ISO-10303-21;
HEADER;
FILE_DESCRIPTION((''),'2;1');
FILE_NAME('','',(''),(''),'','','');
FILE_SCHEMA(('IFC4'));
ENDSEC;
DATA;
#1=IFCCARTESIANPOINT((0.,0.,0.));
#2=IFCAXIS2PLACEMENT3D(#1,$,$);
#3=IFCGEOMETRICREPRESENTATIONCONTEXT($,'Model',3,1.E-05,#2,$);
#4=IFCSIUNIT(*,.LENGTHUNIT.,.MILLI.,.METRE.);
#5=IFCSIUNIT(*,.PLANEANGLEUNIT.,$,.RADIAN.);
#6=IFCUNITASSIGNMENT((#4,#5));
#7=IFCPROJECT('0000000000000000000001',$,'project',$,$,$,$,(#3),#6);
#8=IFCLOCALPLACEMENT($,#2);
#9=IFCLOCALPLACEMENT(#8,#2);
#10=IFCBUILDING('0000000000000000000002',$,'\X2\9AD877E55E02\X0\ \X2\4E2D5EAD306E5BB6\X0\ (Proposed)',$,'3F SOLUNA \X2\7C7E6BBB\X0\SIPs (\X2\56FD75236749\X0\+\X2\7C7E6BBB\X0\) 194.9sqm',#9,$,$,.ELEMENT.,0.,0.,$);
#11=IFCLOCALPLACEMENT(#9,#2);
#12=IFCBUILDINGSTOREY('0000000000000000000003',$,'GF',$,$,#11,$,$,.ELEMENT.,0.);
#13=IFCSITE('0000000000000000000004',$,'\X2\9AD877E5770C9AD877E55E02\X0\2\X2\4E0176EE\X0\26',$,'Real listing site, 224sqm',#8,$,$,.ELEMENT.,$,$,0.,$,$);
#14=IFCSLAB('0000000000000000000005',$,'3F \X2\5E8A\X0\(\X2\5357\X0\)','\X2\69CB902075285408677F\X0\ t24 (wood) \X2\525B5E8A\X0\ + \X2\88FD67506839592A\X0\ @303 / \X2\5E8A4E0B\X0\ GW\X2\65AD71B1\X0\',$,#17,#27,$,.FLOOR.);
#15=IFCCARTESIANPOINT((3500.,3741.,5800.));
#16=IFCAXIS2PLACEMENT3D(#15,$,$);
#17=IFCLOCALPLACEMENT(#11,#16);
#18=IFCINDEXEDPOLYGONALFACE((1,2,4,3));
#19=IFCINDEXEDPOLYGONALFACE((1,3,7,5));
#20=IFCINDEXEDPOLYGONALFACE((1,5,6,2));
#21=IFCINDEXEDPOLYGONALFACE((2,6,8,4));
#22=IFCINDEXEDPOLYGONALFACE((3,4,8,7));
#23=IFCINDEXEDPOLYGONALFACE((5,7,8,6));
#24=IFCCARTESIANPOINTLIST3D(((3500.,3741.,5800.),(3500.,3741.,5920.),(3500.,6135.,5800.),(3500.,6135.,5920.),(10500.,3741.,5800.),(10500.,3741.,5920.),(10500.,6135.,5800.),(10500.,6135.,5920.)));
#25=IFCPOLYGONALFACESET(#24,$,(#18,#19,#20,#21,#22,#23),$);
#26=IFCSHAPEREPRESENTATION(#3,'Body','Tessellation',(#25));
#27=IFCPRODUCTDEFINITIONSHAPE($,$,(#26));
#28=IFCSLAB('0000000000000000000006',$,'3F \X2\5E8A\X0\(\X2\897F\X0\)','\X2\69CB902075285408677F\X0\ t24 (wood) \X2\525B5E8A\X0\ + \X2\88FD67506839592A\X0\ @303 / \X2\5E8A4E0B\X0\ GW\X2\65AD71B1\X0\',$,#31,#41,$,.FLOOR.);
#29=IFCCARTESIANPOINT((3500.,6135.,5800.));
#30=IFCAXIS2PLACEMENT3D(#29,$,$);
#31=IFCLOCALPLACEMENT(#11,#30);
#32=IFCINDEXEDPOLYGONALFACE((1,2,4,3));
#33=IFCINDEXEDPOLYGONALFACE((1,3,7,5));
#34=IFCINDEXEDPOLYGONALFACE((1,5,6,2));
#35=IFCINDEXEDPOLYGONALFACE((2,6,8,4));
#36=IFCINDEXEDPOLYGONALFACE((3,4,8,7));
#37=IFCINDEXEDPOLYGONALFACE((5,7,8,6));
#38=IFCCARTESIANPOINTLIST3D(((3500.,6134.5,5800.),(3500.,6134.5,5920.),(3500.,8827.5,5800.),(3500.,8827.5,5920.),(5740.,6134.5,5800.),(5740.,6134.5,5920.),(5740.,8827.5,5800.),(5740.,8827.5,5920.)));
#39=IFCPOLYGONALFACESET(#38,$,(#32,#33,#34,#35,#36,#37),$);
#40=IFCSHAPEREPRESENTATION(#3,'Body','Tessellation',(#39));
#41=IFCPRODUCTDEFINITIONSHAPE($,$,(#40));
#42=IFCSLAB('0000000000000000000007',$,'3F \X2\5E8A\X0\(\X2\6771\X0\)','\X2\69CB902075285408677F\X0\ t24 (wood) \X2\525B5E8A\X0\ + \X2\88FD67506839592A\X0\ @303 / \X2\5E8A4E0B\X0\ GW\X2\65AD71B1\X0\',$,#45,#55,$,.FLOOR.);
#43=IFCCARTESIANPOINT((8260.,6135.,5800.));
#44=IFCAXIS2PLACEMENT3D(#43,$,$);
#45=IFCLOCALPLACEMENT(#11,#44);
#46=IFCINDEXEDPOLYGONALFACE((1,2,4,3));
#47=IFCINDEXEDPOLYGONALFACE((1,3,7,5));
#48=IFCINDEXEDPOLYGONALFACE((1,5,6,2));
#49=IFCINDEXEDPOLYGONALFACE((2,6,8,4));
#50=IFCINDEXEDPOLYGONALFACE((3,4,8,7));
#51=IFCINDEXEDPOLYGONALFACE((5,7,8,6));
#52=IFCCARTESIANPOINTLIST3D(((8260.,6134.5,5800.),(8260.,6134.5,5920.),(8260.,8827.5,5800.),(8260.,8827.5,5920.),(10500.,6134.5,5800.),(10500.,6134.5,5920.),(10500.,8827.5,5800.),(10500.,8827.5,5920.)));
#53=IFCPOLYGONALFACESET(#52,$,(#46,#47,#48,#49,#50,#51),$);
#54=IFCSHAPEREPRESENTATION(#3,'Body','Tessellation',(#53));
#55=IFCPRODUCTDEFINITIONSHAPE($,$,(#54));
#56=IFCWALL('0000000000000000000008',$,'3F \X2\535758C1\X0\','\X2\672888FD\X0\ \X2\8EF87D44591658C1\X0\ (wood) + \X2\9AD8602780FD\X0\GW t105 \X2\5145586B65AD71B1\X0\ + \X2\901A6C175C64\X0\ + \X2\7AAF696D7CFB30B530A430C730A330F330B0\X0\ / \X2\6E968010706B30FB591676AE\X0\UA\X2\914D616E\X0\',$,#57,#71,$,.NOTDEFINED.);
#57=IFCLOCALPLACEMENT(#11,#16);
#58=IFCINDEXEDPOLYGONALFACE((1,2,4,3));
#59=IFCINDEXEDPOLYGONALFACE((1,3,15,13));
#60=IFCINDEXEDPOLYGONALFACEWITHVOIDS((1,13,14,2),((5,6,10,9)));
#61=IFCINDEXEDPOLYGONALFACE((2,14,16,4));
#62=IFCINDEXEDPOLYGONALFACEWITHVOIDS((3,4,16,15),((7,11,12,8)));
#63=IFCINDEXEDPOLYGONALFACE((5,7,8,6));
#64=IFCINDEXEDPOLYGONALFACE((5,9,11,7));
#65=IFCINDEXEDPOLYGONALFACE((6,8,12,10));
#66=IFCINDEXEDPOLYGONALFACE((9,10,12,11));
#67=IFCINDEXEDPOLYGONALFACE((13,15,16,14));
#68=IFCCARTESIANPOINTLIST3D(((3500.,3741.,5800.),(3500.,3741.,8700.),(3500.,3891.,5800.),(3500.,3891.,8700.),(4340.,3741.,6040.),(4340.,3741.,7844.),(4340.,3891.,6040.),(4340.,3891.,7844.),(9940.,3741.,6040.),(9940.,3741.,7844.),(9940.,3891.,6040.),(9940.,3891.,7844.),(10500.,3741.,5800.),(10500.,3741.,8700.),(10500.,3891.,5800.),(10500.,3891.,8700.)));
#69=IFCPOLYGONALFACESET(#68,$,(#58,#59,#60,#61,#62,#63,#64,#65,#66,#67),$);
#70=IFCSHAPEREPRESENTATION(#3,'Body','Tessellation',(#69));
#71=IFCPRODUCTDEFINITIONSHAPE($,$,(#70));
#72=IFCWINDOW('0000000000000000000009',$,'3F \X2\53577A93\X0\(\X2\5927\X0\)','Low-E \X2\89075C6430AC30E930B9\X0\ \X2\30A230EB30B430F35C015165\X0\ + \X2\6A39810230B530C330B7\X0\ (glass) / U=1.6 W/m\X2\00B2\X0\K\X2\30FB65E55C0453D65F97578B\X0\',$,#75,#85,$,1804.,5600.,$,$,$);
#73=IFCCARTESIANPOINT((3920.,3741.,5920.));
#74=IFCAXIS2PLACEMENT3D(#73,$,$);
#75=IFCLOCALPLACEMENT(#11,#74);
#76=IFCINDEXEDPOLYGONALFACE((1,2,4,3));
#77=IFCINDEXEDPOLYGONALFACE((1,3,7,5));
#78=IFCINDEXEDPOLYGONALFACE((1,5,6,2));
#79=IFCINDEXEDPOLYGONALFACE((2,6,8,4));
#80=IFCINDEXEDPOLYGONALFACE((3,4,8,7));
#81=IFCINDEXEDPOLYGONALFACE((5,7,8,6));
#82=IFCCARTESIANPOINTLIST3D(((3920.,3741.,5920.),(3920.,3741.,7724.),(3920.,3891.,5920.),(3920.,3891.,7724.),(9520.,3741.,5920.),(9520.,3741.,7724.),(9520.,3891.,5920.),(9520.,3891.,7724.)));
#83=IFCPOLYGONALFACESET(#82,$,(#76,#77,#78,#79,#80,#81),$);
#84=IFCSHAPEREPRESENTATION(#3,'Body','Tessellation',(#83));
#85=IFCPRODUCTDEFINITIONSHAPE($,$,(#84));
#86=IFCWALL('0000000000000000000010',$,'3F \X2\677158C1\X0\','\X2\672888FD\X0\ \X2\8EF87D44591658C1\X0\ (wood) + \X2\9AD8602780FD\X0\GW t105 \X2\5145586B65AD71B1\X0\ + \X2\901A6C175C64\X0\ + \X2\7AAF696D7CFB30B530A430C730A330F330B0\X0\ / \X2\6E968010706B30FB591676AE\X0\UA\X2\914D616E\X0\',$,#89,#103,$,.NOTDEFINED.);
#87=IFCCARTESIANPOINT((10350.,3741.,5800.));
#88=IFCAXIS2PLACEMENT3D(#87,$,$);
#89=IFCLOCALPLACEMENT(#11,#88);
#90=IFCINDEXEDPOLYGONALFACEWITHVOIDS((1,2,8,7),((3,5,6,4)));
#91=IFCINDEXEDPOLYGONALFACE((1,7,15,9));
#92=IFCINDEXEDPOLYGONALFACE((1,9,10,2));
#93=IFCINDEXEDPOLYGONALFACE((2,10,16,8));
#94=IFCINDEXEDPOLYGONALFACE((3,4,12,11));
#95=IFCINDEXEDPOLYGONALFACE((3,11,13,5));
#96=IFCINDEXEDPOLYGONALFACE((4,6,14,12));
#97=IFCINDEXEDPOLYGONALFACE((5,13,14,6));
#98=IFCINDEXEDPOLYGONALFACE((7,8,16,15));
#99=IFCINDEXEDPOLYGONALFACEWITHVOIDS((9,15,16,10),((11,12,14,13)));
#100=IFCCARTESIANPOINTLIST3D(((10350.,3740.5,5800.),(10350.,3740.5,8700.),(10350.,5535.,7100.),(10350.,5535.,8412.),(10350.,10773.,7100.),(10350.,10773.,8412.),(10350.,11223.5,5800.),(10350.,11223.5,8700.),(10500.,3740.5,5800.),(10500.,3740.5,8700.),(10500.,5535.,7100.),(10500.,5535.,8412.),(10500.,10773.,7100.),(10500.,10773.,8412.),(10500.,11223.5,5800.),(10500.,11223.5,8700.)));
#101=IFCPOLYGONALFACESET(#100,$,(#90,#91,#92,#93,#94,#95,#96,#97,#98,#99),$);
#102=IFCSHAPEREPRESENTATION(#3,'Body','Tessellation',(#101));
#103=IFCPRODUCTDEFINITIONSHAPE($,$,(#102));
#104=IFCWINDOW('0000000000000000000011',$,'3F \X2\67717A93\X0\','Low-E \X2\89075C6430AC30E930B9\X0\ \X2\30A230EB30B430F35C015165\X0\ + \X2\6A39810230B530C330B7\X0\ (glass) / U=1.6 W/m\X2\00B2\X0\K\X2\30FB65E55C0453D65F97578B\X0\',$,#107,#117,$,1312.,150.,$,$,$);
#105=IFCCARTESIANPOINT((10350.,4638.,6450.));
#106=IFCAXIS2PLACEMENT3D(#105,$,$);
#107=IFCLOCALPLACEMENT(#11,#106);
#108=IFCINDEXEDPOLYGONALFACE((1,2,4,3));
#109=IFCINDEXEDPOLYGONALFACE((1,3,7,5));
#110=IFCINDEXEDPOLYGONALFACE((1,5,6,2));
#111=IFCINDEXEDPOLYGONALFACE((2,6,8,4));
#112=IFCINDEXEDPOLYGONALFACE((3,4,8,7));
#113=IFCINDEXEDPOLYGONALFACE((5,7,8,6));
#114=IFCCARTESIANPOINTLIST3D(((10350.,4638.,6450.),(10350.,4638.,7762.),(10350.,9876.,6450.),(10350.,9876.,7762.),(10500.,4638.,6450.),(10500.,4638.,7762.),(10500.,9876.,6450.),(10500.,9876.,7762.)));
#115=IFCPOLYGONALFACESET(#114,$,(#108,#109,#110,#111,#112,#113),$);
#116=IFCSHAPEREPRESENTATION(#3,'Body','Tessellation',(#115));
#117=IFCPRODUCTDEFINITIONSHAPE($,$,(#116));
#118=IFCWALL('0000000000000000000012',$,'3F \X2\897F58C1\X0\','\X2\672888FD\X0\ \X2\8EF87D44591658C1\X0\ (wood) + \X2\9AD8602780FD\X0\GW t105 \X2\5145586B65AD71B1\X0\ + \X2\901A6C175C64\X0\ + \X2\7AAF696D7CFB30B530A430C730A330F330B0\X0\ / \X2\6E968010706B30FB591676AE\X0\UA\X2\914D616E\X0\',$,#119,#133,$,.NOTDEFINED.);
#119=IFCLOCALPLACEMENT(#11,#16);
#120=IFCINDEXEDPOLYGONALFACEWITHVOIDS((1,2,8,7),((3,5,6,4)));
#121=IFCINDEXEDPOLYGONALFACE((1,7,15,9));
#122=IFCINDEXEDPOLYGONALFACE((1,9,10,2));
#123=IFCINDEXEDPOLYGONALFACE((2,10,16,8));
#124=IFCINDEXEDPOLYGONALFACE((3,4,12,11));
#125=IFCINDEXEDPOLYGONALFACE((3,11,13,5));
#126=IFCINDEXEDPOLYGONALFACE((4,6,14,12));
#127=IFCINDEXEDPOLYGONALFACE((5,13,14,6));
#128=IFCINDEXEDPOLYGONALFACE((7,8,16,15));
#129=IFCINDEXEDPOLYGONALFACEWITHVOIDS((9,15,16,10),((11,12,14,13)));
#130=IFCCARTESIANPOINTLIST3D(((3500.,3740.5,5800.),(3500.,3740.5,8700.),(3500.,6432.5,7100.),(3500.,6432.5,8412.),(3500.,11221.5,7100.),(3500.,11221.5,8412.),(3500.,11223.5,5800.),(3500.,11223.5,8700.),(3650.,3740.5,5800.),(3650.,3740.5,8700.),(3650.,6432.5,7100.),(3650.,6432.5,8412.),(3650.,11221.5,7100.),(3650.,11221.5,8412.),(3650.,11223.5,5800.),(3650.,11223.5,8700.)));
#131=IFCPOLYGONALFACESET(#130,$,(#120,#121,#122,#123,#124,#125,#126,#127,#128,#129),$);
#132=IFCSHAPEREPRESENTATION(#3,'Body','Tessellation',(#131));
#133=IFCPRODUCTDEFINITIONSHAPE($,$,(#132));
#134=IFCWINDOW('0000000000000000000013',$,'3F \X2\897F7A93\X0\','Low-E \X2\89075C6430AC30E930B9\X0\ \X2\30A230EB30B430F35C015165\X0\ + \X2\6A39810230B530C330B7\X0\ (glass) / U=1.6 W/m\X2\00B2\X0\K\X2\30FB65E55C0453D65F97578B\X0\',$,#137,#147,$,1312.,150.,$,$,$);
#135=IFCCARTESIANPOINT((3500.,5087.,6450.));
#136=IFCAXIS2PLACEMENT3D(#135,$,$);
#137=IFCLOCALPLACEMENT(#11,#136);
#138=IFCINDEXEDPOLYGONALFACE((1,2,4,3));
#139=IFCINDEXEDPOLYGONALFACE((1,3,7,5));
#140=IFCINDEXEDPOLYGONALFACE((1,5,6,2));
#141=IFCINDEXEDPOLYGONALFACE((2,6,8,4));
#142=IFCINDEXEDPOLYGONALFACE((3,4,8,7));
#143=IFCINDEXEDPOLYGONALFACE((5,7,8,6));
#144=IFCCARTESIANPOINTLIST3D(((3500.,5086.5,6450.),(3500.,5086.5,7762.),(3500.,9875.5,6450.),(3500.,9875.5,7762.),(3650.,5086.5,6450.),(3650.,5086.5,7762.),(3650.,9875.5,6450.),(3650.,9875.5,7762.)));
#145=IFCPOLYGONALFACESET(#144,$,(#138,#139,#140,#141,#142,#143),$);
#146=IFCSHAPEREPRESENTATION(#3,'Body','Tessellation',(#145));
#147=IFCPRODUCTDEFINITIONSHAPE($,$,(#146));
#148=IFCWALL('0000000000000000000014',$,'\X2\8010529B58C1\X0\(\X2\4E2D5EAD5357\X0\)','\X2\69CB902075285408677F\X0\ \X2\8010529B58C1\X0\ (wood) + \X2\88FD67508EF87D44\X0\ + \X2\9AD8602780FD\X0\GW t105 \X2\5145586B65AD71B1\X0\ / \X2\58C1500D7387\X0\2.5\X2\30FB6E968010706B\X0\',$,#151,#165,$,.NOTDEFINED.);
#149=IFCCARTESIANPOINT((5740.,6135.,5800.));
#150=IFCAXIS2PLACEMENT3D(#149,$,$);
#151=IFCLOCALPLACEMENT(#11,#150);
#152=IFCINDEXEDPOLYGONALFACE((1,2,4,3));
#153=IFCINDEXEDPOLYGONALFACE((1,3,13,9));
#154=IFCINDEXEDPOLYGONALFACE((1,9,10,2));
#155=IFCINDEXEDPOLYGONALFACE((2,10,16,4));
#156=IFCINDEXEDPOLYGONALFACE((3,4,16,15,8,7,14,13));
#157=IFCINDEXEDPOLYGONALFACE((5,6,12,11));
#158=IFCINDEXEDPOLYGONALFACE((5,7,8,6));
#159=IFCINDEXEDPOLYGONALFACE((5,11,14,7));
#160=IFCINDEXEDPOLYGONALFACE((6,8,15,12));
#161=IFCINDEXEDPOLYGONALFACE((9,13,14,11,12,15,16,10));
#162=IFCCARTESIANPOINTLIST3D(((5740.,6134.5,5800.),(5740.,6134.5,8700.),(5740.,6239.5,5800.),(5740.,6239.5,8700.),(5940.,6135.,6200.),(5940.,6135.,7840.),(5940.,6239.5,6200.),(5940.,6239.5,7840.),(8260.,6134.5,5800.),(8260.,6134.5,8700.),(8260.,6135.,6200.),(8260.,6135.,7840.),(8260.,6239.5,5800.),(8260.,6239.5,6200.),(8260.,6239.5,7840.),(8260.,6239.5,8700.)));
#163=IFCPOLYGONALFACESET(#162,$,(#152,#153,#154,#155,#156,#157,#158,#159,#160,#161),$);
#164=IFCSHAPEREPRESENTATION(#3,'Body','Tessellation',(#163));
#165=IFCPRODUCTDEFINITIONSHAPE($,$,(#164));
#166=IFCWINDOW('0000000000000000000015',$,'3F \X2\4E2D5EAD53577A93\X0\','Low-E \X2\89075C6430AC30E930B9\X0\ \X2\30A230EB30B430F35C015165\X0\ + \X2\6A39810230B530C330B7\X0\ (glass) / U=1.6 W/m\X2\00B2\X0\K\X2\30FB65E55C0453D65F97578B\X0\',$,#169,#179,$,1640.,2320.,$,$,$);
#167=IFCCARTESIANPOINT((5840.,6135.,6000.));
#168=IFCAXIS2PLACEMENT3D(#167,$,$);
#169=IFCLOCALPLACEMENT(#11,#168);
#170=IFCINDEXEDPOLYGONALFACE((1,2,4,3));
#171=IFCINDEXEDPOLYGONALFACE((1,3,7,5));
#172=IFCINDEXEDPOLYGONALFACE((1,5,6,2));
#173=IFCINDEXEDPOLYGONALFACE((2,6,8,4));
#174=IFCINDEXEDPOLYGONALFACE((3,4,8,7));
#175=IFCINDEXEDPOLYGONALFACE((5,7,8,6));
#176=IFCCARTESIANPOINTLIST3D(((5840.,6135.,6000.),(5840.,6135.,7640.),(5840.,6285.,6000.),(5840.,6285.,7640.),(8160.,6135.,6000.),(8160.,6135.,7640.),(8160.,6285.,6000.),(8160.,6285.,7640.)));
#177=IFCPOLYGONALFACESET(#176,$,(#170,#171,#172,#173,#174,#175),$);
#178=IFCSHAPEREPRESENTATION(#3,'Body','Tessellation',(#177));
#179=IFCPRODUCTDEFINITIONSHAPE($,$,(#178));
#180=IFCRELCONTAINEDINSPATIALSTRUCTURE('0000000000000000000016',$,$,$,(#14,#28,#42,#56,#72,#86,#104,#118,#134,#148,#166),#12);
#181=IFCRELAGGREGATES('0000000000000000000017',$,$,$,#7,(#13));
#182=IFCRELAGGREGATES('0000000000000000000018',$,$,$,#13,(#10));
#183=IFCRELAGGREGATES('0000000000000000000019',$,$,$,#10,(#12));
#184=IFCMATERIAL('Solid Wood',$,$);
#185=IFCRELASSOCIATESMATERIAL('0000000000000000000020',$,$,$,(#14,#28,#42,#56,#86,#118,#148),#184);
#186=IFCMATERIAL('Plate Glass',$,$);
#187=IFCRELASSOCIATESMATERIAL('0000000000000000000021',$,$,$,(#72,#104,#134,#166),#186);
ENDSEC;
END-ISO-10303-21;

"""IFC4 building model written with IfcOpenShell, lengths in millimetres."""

from ifc_helpers import new_model, si_unit, frame, frame_2d, origin, place, context, project, spatial, rectangle, extrude, material, element, fill, save


model = new_model("IFC4")

# Units and contexts
model_context = context("Model", 3, precision=1e-05, world=origin())
ifc_project = project(units=[si_unit("LENGTHUNIT", "METRE", prefix="MILLI"), si_unit("PLANEANGLEUNIT", "RADIAN")], contexts=[model_context])

# Site, building, storey
site_placement = place(None, origin())
site = spatial("IfcSite", under=ifc_project, at=site_placement, Name="高知県高知市2丁目26", ObjectType="Real listing site, 224sqm", CompositionType="ELEMENT", RefElevation=0.0)
building_placement = place(site_placement, origin())
building = spatial("IfcBuilding", under=site, at=building_placement, Name="高知市 中庭の家 (Proposed)", ObjectType="3F SOLUNA 籾殻SIPs (国産杉+籾殻) 194.9sqm", CompositionType="ELEMENT", ElevationOfRefHeight=0.0, ElevationOfTerrain=0.0)
storey_placement = place(building_placement, origin())
storey = spatial("IfcBuildingStorey", under=building, at=storey_placement, Name="GF", CompositionType="ELEMENT", Elevation=0.0)

# Slabs
ifc_material_1 = material(Name="Solid Wood")
slab_1_placement = place(storey_placement, frame((3500.0, 3741.0, 5800.0)))
element("IfcSlab", 1, at=slab_1_placement, inside=storey, material=ifc_material_1, Name="3F 床(南)", Description="構造用合板 t24 (wood) 剛床 + 製材根太 @303 / 床下 GW断熱", PredefinedType="FLOOR", context=model_context, shape_type="SweptSolid", body=[
    extrude(rectangle(XDim=7000.0, YDim=2394.0, at=frame_2d((3500.0, 1197.0))), frame((3500.0, 3741.0, 5800.0)), (0.0, 0.0, 1.0), 120.0),
])
slab_2_placement = place(storey_placement, frame((3500.0, 6135.0, 5800.0)))
element("IfcSlab", 2, at=slab_2_placement, inside=storey, material=ifc_material_1, Name="3F 床(西)", Description="構造用合板 t24 (wood) 剛床 + 製材根太 @303 / 床下 GW断熱", PredefinedType="FLOOR", context=model_context, shape_type="SweptSolid", body=[
    extrude(rectangle(XDim=2240.0, YDim=2693.0, at=frame_2d((1120.0, 1346.0))), frame((3500.0, 6135.0, 5800.0)), (0.0, 0.0, 1.0), 120.0),
])
slab_3_placement = place(storey_placement, frame((8260.0, 6135.0, 5800.0)))
element("IfcSlab", 3, at=slab_3_placement, inside=storey, material=ifc_material_1, Name="3F 床(東)", Description="構造用合板 t24 (wood) 剛床 + 製材根太 @303 / 床下 GW断熱", PredefinedType="FLOOR", context=model_context, shape_type="SweptSolid", body=[
    extrude(rectangle(XDim=2240.0, YDim=2693.0, at=frame_2d((1120.0, 1346.0))), frame((8260.0, 6135.0, 5800.0)), (0.0, 0.0, 1.0), 120.0),
])

# Walls, openings, windows
wall_1_placement = place(storey_placement, frame((3500.0, 3741.0, 5800.0)))
wall_1 = element("IfcWall", 4, at=wall_1_placement, inside=storey, material=ifc_material_1, Name="3F 南壁", Description="木製 軸組外壁 (wood) + 高性能GW t105 充填断熱 + 通気層 + 窯業系サイディング / 準耐火・外皮UA配慮", PredefinedType="NOTDEFINED", context=model_context, shape_type="SweptSolid", body=[
    extrude(rectangle(XDim=7000.0, YDim=150.0, at=frame_2d((3500.0, 75.0))), frame((3500.0, 3741.0, 5800.0)), (0.0, 0.0, 1.0), 2900.0),
])
opening_1_placement = place(storey_placement, frame((3920.0, 3741.0, 5920.0)))
opening_1 = element("IfcOpeningElement", 5, at=opening_1_placement, cuts=wall_1, PredefinedType="NOTDEFINED", context=model_context, shape_type="SweptSolid", body=[
    extrude(rectangle(XDim=5600.0, YDim=150.0, at=frame_2d((2800.0, 75.0))), frame((3920.0, 3741.0, 5920.0)), (0.0, 0.0, 1.0), 1804.0),
])
ifc_material_2 = material(Name="Plate Glass")
window_1_placement = place(storey_placement, frame((3920.0, 3741.0, 5920.0)))
window_1 = element("IfcWindow", 6, at=window_1_placement, inside=storey, material=ifc_material_2, Name="3F 南窓(大)", Description="Low-E 複層ガラス アルゴン封入 + 樹脂サッシ (glass) / U=1.6 W/m²K・日射取得型", OverallHeight=1804.0, OverallWidth=5600.0, context=model_context, shape_type="SweptSolid", body=[
    extrude(rectangle(XDim=5600.0, YDim=150.0, at=frame_2d((2800.0, 75.0))), frame((3920.0, 3741.0, 5920.0)), (0.0, 0.0, 1.0), 1804.0),
])
fill(opening_1, window_1)
wall_2_placement = place(storey_placement, frame((10350.0, 3741.0, 5800.0)))
wall_2 = element("IfcWall", 7, at=wall_2_placement, inside=storey, material=ifc_material_1, Name="3F 東壁", Description="木製 軸組外壁 (wood) + 高性能GW t105 充填断熱 + 通気層 + 窯業系サイディング / 準耐火・外皮UA配慮", PredefinedType="NOTDEFINED", context=model_context, shape_type="SweptSolid", body=[
    extrude(rectangle(XDim=150.0, YDim=7483.0, at=frame_2d((75.0, 3741.0))), frame((10350.0, 3741.0, 5800.0)), (0.0, 0.0, 1.0), 2900.0),
])
opening_2_placement = place(storey_placement, frame((10350.0, 4638.0, 6450.0)))
opening_2 = element("IfcOpeningElement", 8, at=opening_2_placement, cuts=wall_2, PredefinedType="NOTDEFINED", context=model_context, shape_type="SweptSolid", body=[
    extrude(rectangle(XDim=150.0, YDim=5238.0, at=frame_2d((75.0, 2619.0))), frame((10350.0, 4638.0, 6450.0)), (0.0, 0.0, 1.0), 1312.0),
])
window_2_placement = place(storey_placement, frame((10350.0, 4638.0, 6450.0)))
window_2 = element("IfcWindow", 9, at=window_2_placement, inside=storey, material=ifc_material_2, Name="3F 東窓", Description="Low-E 複層ガラス アルゴン封入 + 樹脂サッシ (glass) / U=1.6 W/m²K・日射取得型", OverallHeight=1312.0, OverallWidth=150.0, context=model_context, shape_type="SweptSolid", body=[
    extrude(rectangle(XDim=150.0, YDim=5238.0, at=frame_2d((75.0, 2619.0))), frame((10350.0, 4638.0, 6450.0)), (0.0, 0.0, 1.0), 1312.0),
])
fill(opening_2, window_2)
wall_3_placement = place(storey_placement, frame((3500.0, 3741.0, 5800.0)))
wall_3 = element("IfcWall", 10, at=wall_3_placement, inside=storey, material=ifc_material_1, Name="3F 西壁", Description="木製 軸組外壁 (wood) + 高性能GW t105 充填断熱 + 通気層 + 窯業系サイディング / 準耐火・外皮UA配慮", PredefinedType="NOTDEFINED", context=model_context, shape_type="SweptSolid", body=[
    extrude(rectangle(XDim=150.0, YDim=7483.0, at=frame_2d((75.0, 3741.0))), frame((3500.0, 3741.0, 5800.0)), (0.0, 0.0, 1.0), 2900.0),
])
opening_3_placement = place(storey_placement, frame((3500.0, 5087.0, 6450.0)))
opening_3 = element("IfcOpeningElement", 11, at=opening_3_placement, cuts=wall_3, PredefinedType="NOTDEFINED", context=model_context, shape_type="SweptSolid", body=[
    extrude(rectangle(XDim=150.0, YDim=4789.0, at=frame_2d((75.0, 2394.0))), frame((3500.0, 5087.0, 6450.0)), (0.0, 0.0, 1.0), 1312.0),
])
window_3_placement = place(storey_placement, frame((3500.0, 5087.0, 6450.0)))
window_3 = element("IfcWindow", 12, at=window_3_placement, inside=storey, material=ifc_material_2, Name="3F 西窓", Description="Low-E 複層ガラス アルゴン封入 + 樹脂サッシ (glass) / U=1.6 W/m²K・日射取得型", OverallHeight=1312.0, OverallWidth=150.0, context=model_context, shape_type="SweptSolid", body=[
    extrude(rectangle(XDim=150.0, YDim=4789.0, at=frame_2d((75.0, 2394.0))), frame((3500.0, 5087.0, 6450.0)), (0.0, 0.0, 1.0), 1312.0),
])
fill(opening_3, window_3)
wall_4_placement = place(storey_placement, frame((5740.0, 6135.0, 5800.0)))
wall_4 = element("IfcWall", 13, at=wall_4_placement, inside=storey, material=ifc_material_1, Name="耐力壁(中庭南)", Description="構造用合板 耐力壁 (wood) + 製材軸組 + 高性能GW t105 充填断熱 / 壁倍率2.5・準耐火", PredefinedType="NOTDEFINED", context=model_context, shape_type="SweptSolid", body=[
    extrude(rectangle(XDim=2520.0, YDim=105.0, at=frame_2d((1260.0, 52.0))), frame((5740.0, 6135.0, 5800.0)), (0.0, 0.0, 1.0), 2900.0),
])
opening_4_placement = place(storey_placement, frame((5840.0, 6135.0, 6000.0)))
opening_4 = element("IfcOpeningElement", 14, at=opening_4_placement, cuts=wall_4, PredefinedType="NOTDEFINED", context=model_context, shape_type="SweptSolid", body=[
    extrude(rectangle(XDim=2320.0, YDim=150.0, at=frame_2d((1160.0, 75.0))), frame((5840.0, 6135.0, 6000.0)), (0.0, 0.0, 1.0), 1640.0),
])
window_4_placement = place(storey_placement, frame((5840.0, 6135.0, 6000.0)))
window_4 = element("IfcWindow", 15, at=window_4_placement, inside=storey, material=ifc_material_2, Name="3F 中庭南窓", Description="Low-E 複層ガラス アルゴン封入 + 樹脂サッシ (glass) / U=1.6 W/m²K・日射取得型", OverallHeight=1640.0, OverallWidth=2320.0, context=model_context, shape_type="SweptSolid", body=[
    extrude(rectangle(XDim=2320.0, YDim=150.0, at=frame_2d((1160.0, 75.0))), frame((5840.0, 6135.0, 6000.0)), (0.0, 0.0, 1.0), 1640.0),
])
fill(opening_4, window_4)

save(model, "model.ifc")
